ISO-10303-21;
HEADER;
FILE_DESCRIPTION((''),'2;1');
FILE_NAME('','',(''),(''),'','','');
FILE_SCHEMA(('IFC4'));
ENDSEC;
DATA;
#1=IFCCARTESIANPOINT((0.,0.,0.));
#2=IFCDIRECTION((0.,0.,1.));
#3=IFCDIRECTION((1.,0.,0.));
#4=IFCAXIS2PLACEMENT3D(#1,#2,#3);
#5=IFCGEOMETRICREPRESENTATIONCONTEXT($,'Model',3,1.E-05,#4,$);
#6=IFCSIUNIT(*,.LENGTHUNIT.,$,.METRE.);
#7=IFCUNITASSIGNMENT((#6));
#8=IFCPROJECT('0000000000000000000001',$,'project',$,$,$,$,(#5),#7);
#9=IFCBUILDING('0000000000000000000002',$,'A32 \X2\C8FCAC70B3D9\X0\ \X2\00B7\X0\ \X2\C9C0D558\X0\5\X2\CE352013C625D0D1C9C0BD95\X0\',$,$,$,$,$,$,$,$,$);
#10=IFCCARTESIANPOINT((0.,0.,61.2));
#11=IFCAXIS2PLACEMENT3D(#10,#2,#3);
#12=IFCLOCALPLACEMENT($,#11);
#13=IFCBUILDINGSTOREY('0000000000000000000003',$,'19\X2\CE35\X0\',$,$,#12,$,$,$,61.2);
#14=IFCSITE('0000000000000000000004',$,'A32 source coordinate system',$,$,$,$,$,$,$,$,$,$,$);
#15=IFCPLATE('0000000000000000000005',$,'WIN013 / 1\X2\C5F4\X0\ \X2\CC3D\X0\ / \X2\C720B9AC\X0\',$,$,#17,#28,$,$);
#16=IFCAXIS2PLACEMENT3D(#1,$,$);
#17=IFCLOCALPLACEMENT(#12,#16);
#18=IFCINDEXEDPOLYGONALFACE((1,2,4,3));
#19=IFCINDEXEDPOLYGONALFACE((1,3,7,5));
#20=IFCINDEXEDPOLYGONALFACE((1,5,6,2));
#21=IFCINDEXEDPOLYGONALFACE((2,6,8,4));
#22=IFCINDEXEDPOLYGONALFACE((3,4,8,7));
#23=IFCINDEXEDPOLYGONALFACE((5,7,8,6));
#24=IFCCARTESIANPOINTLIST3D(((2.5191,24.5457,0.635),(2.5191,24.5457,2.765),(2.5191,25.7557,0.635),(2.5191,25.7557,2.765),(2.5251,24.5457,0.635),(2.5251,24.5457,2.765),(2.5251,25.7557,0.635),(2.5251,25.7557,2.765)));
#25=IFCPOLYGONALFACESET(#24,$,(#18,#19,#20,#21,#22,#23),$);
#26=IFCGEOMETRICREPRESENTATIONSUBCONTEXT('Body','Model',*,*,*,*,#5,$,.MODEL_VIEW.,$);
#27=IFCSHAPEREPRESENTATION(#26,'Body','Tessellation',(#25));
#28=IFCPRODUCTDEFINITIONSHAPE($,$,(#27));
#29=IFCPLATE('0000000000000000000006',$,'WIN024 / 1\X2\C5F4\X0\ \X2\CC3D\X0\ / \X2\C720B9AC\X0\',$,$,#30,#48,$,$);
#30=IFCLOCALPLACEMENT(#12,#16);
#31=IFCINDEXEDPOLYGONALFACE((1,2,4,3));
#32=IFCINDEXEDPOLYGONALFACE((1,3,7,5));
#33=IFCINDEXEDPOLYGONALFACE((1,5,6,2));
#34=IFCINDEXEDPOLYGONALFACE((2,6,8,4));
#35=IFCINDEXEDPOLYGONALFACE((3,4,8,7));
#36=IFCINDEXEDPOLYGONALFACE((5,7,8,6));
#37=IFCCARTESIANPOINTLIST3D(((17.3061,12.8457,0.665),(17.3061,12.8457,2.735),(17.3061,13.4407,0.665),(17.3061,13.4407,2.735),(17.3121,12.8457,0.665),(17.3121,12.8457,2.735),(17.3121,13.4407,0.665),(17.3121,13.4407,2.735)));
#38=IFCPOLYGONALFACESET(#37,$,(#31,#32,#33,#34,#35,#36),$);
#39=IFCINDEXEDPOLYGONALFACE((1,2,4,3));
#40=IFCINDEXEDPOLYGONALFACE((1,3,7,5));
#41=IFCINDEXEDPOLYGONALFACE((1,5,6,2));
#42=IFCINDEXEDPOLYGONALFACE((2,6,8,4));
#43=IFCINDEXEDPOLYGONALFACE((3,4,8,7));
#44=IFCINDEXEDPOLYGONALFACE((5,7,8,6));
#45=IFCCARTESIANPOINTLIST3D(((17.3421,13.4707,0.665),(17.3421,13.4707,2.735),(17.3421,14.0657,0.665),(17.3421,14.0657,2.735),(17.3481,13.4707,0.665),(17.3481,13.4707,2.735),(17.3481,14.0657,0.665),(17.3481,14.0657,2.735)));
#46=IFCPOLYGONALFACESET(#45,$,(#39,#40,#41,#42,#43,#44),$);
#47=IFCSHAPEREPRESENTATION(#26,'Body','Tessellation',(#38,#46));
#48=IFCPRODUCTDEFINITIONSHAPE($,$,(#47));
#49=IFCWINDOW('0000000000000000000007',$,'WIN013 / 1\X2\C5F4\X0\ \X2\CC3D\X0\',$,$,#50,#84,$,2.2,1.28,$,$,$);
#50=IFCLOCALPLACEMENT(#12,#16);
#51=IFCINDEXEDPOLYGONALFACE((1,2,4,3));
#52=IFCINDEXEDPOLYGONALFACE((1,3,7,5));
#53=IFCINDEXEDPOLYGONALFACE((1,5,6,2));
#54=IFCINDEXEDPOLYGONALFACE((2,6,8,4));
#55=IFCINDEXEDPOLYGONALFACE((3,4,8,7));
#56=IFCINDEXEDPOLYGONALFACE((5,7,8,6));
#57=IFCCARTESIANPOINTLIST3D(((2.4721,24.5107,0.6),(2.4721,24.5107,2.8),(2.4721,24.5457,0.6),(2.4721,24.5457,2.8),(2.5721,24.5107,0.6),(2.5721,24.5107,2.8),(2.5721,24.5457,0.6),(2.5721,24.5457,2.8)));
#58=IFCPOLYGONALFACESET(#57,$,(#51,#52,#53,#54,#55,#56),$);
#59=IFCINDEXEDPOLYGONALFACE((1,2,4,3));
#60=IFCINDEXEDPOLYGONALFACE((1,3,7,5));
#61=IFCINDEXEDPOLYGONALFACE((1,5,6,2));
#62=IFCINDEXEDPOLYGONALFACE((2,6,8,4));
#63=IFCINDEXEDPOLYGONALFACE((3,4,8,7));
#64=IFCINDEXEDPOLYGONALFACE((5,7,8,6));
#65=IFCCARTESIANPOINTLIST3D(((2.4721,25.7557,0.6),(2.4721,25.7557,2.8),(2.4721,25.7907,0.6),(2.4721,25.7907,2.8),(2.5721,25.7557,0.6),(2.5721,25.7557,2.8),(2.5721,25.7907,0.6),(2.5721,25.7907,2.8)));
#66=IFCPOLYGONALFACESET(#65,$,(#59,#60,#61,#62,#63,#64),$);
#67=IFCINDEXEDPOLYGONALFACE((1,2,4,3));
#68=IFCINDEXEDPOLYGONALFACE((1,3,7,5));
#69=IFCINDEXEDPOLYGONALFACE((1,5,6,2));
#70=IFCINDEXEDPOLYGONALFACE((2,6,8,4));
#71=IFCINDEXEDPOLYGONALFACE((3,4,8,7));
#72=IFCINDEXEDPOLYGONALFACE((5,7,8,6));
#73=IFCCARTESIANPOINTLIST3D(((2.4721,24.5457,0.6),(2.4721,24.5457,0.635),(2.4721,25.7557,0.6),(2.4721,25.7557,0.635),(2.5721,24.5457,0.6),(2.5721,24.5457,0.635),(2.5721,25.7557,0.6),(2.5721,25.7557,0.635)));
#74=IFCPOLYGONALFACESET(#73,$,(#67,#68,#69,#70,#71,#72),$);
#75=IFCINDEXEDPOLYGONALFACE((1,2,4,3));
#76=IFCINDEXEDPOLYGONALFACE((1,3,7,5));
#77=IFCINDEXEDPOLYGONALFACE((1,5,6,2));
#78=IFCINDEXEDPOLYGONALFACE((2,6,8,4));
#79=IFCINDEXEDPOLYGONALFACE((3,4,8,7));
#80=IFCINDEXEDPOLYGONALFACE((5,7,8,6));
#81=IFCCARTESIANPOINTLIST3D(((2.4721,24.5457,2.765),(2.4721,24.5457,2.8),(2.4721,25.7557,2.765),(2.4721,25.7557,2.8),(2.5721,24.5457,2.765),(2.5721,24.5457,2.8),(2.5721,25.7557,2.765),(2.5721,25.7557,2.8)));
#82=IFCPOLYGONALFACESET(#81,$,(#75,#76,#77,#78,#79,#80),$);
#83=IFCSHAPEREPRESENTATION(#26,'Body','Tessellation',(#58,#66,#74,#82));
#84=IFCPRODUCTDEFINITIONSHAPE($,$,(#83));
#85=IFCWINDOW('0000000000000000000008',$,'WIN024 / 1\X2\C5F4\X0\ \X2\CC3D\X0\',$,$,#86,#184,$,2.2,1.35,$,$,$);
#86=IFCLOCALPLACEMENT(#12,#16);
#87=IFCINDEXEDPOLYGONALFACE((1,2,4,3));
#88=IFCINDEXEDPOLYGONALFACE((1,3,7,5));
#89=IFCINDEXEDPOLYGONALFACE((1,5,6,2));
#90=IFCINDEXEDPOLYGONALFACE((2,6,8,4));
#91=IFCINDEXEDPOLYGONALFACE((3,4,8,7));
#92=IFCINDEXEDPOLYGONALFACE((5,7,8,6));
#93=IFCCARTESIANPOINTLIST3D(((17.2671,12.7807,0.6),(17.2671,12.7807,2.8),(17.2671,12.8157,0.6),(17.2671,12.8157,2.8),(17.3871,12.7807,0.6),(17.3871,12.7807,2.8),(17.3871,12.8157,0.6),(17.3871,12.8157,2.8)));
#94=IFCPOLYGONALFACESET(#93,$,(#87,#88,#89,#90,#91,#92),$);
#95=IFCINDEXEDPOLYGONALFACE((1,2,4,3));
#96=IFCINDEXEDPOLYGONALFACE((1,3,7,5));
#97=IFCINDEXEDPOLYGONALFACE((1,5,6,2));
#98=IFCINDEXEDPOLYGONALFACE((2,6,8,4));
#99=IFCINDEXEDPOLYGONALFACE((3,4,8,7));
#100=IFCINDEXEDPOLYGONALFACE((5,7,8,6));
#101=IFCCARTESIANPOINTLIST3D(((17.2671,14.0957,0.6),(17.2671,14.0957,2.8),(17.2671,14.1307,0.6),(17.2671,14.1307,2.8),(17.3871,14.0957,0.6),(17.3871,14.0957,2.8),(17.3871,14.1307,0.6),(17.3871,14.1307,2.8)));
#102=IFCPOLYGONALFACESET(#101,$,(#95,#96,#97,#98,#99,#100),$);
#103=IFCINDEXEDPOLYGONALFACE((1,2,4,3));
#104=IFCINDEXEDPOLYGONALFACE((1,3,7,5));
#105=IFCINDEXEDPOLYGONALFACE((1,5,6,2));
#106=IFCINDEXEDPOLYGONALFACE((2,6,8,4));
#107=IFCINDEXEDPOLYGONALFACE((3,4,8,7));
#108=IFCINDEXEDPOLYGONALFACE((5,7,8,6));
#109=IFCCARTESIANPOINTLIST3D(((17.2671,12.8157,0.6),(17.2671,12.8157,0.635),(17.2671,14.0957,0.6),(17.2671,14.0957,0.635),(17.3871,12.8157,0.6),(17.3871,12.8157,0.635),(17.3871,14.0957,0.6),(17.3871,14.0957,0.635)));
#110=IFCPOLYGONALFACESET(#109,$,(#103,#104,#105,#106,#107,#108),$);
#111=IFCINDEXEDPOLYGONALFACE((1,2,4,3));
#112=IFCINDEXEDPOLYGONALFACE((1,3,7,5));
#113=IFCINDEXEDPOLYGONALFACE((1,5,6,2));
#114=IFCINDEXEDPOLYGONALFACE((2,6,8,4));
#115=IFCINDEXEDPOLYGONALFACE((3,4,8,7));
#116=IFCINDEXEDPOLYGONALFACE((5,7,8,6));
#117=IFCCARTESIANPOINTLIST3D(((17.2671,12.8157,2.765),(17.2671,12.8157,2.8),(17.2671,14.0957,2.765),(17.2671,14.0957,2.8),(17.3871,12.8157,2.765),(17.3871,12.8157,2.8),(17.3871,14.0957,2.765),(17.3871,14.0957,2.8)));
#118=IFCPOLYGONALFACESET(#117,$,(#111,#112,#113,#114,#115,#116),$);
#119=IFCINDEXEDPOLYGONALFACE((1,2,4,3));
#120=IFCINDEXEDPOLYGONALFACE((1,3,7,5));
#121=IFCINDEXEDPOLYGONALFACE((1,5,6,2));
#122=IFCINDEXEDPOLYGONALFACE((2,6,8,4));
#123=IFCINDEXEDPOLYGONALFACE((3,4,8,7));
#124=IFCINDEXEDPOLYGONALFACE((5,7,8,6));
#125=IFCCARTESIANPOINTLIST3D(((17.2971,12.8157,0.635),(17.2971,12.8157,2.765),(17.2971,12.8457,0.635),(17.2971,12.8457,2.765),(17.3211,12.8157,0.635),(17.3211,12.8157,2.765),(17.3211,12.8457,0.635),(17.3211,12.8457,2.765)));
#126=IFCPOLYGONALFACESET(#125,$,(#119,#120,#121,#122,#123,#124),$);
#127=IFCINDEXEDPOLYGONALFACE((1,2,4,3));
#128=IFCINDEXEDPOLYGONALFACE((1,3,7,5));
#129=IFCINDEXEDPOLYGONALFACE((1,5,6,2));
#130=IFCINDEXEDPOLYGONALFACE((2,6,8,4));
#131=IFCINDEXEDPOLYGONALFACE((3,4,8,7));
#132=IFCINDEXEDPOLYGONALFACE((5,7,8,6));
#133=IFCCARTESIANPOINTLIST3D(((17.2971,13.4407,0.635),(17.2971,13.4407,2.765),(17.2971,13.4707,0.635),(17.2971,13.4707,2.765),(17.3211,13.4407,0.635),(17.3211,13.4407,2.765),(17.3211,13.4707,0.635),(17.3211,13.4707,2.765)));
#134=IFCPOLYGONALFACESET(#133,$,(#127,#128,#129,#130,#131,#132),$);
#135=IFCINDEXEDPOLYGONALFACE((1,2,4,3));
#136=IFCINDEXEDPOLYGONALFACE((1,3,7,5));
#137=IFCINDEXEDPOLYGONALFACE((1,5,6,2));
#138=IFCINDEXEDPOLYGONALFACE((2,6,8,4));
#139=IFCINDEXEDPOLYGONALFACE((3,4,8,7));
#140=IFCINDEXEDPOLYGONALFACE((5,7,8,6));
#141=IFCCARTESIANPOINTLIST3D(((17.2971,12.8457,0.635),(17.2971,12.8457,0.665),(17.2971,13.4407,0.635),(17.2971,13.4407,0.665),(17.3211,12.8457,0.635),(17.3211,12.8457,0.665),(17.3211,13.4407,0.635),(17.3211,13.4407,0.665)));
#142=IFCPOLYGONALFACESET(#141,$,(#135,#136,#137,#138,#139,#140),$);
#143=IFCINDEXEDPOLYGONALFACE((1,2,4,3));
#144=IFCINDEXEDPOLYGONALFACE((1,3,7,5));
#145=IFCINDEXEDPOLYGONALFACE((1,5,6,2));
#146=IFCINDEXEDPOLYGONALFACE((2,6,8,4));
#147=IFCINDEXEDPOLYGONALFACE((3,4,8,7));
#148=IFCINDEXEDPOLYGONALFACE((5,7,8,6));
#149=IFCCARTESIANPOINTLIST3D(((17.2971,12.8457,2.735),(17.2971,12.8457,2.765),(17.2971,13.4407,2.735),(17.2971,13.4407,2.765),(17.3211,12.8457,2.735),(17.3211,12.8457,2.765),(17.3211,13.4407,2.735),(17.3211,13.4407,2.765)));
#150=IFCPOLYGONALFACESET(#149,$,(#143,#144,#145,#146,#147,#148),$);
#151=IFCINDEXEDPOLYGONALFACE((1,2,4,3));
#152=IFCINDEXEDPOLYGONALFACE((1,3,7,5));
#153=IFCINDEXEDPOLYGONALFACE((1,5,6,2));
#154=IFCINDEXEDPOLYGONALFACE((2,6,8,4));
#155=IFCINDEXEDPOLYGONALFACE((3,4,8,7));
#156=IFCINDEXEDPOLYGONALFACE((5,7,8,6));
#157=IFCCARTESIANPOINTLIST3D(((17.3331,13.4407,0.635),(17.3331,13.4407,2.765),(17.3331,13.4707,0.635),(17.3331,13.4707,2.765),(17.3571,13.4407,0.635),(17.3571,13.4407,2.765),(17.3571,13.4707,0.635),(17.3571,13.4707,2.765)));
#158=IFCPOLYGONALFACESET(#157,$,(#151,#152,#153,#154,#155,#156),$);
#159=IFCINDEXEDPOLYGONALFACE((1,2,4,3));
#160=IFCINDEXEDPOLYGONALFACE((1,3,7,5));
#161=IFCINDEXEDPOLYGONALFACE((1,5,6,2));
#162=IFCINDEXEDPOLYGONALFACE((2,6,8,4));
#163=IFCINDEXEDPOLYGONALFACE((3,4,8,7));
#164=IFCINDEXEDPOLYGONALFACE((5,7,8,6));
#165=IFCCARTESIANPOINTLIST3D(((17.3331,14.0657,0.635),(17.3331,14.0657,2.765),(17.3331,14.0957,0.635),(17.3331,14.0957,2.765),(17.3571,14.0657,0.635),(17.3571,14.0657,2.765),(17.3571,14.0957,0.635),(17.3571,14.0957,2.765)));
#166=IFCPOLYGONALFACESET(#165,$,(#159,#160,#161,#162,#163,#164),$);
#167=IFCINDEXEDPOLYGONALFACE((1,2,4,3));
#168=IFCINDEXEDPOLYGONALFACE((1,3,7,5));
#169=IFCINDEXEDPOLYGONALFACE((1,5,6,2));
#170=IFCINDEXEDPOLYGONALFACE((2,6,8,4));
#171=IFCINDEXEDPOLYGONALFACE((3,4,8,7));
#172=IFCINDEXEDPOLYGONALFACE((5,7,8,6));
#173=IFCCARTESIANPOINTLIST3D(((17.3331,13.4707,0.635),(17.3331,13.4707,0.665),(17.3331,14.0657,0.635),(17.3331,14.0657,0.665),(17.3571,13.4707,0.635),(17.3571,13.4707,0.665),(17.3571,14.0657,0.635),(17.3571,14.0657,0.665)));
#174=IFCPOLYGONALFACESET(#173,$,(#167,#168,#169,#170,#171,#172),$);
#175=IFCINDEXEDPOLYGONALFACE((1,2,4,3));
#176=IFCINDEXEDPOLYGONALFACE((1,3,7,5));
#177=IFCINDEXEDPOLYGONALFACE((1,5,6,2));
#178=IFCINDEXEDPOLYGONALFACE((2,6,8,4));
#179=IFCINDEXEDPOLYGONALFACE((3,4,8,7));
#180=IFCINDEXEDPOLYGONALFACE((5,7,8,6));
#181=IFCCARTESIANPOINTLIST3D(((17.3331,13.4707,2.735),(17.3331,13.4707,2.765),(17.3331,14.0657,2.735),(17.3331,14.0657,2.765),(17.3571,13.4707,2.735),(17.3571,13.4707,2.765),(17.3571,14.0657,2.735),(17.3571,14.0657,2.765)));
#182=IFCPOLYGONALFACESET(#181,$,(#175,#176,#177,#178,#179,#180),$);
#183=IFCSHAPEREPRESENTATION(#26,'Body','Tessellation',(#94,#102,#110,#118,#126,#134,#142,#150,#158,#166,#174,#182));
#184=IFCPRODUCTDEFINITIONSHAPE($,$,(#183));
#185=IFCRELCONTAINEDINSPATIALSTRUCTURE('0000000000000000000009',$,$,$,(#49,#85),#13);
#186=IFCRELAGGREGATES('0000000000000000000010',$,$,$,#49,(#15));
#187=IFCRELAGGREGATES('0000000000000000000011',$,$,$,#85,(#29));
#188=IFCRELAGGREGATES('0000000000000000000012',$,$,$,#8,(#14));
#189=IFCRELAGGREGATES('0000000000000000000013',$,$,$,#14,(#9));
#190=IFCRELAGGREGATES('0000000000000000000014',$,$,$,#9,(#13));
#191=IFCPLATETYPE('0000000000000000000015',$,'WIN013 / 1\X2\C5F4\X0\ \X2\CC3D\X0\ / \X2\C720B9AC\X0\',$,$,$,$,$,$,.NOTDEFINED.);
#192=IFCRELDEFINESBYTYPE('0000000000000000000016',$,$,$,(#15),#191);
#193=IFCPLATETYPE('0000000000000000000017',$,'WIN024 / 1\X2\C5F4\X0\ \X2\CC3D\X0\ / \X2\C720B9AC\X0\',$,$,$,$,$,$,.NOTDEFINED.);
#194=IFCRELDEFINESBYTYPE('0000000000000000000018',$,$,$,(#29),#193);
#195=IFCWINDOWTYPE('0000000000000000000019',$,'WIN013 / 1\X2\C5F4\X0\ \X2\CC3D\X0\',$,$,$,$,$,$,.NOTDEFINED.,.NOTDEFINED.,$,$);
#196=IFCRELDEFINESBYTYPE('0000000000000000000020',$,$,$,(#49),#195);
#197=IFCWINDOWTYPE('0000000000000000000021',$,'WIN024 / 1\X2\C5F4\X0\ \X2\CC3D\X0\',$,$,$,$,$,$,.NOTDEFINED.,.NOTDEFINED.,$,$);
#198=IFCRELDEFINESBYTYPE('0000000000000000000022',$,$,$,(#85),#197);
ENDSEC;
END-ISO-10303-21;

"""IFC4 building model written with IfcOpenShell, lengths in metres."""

from ifc_helpers import new_model, si_unit, frame, origin, origin_with_axes, place, context, subcontext, project, spatial, polyline, outline, extrude, source, transform, mapped, type_object, type_shapes, element, aggregate, save


model = new_model("IFC4")

# Units and contexts
model_context = context("Model", 3, precision=1e-05, world=origin_with_axes())
body_context = subcontext(model_context, "Body", "Model", "MODEL_VIEW")
ifc_project = project(units=[si_unit("LENGTHUNIT", "METRE")], contexts=[model_context])

# Plates
plate_type_1 = type_object("IfcPlateType", Name="WIN013 / 1열 창 / 유리", PredefinedType="NOTDEFINED")
shared_shape_1 = source(origin(), body_context, "Body", "SweptSolid", [
    extrude(outline(polyline([(2.5191, 24.5457), (2.5191, 25.7557), (2.5251, 25.7557), (2.5251, 24.5457), (2.5191, 24.5457)])), frame((0.0, 0.0, 0.635)), (0.0, 0.0, 1.0), 2.13),
])
type_shapes(plate_type_1, [shared_shape_1])
storey_placement = place(None, frame((0.0, 0.0, 61.2), z_axis=(0.0, 0.0, 1.0), x_axis=(1.0, 0.0, 0.0)))
window_1_placement = place(storey_placement, origin_with_axes())
plate_1_placement = place(window_1_placement, origin_with_axes())
plate_1 = element("IfcPlate", 1, at=plate_1_placement, type_object=plate_type_1, Name="WIN013 / 1열 창 / 유리", context=body_context, shape_type="MappedRepresentation", body=[
    mapped(shared_shape_1, transform((0.0, 0.0, 0.0), scale=1.0)),
])
plate_type_2 = type_object("IfcPlateType", Name="WIN024 / 1열 창 / 유리", PredefinedType="NOTDEFINED")
shared_shape_2 = source(origin(), body_context, "Body", "SweptSolid", [
    extrude(outline(polyline([(17.3061, 12.8457), (17.3061, 13.4407), (17.3121, 13.4407), (17.3121, 12.8457), (17.3061, 12.8457)])), frame((0.0, 0.0, 0.665)), (0.0, 0.0, 1.0), 2.07),
    extrude(outline(polyline([(17.3421, 13.4707), (17.3421, 14.0657), (17.3481, 14.0657), (17.3481, 13.4707), (17.3421, 13.4707)])), frame((0.0, 0.0, 0.665)), (0.0, 0.0, 1.0), 2.07),
])
type_shapes(plate_type_2, [shared_shape_2])
window_2_placement = place(storey_placement, origin_with_axes())
plate_2_placement = place(window_2_placement, origin_with_axes())
plate_2 = element("IfcPlate", 2, at=plate_2_placement, type_object=plate_type_2, Name="WIN024 / 1열 창 / 유리", context=body_context, shape_type="MappedRepresentation", body=[
    mapped(shared_shape_2, transform((0.0, 0.0, 0.0), scale=1.0)),
])

# Site, building, storey
site = spatial("IfcSite", under=ifc_project, Name="A32 source coordinate system")
building = spatial("IfcBuilding", under=site, Name="A32 주거동 · 지하5층–옥탑지붕")
storey = spatial("IfcBuildingStorey", under=building, at=storey_placement, Name="19층", Elevation=61.2)

# Windows
window_type_1 = type_object("IfcWindowType", Name="WIN013 / 1열 창", PartitioningType="NOTDEFINED", PredefinedType="NOTDEFINED")
shared_shape_3 = source(origin(), body_context, "Body", "SweptSolid", [
    extrude(outline(polyline([(2.4721, 24.5107), (2.4721, 24.5457), (2.5721, 24.5457), (2.5721, 24.5107), (2.4721, 24.5107)])), frame((0.0, 0.0, 0.6)), (0.0, 0.0, 1.0), 2.2),
    extrude(outline(polyline([(2.4721, 25.7557), (2.4721, 25.7907), (2.5721, 25.7907), (2.5721, 25.7557), (2.4721, 25.7557)])), frame((0.0, 0.0, 0.6)), (0.0, 0.0, 1.0), 2.2),
    extrude(outline(polyline([(2.4721, 24.5457), (2.4721, 25.7557), (2.5721, 25.7557), (2.5721, 24.5457), (2.4721, 24.5457)])), frame((0.0, 0.0, 0.6)), (0.0, 0.0, 1.0), 0.035),
    extrude(outline(polyline([(2.4721, 24.5457), (2.4721, 25.7557), (2.5721, 25.7557), (2.5721, 24.5457), (2.4721, 24.5457)])), frame((0.0, 0.0, 2.765)), (0.0, 0.0, 1.0), 0.035),
])
type_shapes(window_type_1, [shared_shape_3])
window_1 = element("IfcWindow", 3, at=window_1_placement, inside=storey, type_object=window_type_1, Name="WIN013 / 1열 창", OverallHeight=2.2, OverallWidth=1.28, context=body_context, shape_type="MappedRepresentation", body=[
    mapped(shared_shape_3, transform((0.0, 0.0, 0.0), scale=1.0)),
])
aggregate(window_1, [plate_1])
window_type_2 = type_object("IfcWindowType", Name="WIN024 / 1열 창", PartitioningType="NOTDEFINED", PredefinedType="NOTDEFINED")
shared_shape_4 = source(origin(), body_context, "Body", "SweptSolid", [
    extrude(outline(polyline([(17.2671, 12.7807), (17.2671, 12.8157), (17.3871, 12.8157), (17.3871, 12.7807), (17.2671, 12.7807)])), frame((0.0, 0.0, 0.6)), (0.0, 0.0, 1.0), 2.2),
    extrude(outline(polyline([(17.2671, 14.0957), (17.2671, 14.1307), (17.3871, 14.1307), (17.3871, 14.0957), (17.2671, 14.0957)])), frame((0.0, 0.0, 0.6)), (0.0, 0.0, 1.0), 2.2),
    extrude(outline(polyline([(17.2671, 12.8157), (17.2671, 14.0957), (17.3871, 14.0957), (17.3871, 12.8157), (17.2671, 12.8157)])), frame((0.0, 0.0, 0.6)), (0.0, 0.0, 1.0), 0.035),
    extrude(outline(polyline([(17.2671, 12.8157), (17.2671, 14.0957), (17.3871, 14.0957), (17.3871, 12.8157), (17.2671, 12.8157)])), frame((0.0, 0.0, 2.765)), (0.0, 0.0, 1.0), 0.035),
    extrude(outline(polyline([(17.2971, 12.8157), (17.2971, 12.8457), (17.3211, 12.8457), (17.3211, 12.8157), (17.2971, 12.8157)])), frame((0.0, 0.0, 0.635)), (0.0, 0.0, 1.0), 2.13),
    extrude(outline(polyline([(17.2971, 13.4407), (17.2971, 13.4707), (17.3211, 13.4707), (17.3211, 13.4407), (17.2971, 13.4407)])), frame((0.0, 0.0, 0.635)), (0.0, 0.0, 1.0), 2.13),
    extrude(outline(polyline([(17.2971, 12.8457), (17.2971, 13.4407), (17.3211, 13.4407), (17.3211, 12.8457), (17.2971, 12.8457)])), frame((0.0, 0.0, 0.635)), (0.0, 0.0, 1.0), 0.03),
    extrude(outline(polyline([(17.2971, 12.8457), (17.2971, 13.4407), (17.3211, 13.4407), (17.3211, 12.8457), (17.2971, 12.8457)])), frame((0.0, 0.0, 2.735)), (0.0, 0.0, 1.0), 0.03),
    extrude(outline(polyline([(17.3331, 13.4407), (17.3331, 13.4707), (17.3571, 13.4707), (17.3571, 13.4407), (17.3331, 13.4407)])), frame((0.0, 0.0, 0.635)), (0.0, 0.0, 1.0), 2.13),
    extrude(outline(polyline([(17.3331, 14.0657), (17.3331, 14.0957), (17.3571, 14.0957), (17.3571, 14.0657), (17.3331, 14.0657)])), frame((0.0, 0.0, 0.635)), (0.0, 0.0, 1.0), 2.13),
    extrude(outline(polyline([(17.3331, 13.4707), (17.3331, 14.0657), (17.3571, 14.0657), (17.3571, 13.4707), (17.3331, 13.4707)])), frame((0.0, 0.0, 0.635)), (0.0, 0.0, 1.0), 0.03),
    extrude(outline(polyline([(17.3331, 13.4707), (17.3331, 14.0657), (17.3571, 14.0657), (17.3571, 13.4707), (17.3331, 13.4707)])), frame((0.0, 0.0, 2.735)), (0.0, 0.0, 1.0), 0.03),
])
type_shapes(window_type_2, [shared_shape_4])
window_2 = element("IfcWindow", 4, at=window_2_placement, inside=storey, type_object=window_type_2, Name="WIN024 / 1열 창", OverallHeight=2.2, OverallWidth=1.35, context=body_context, shape_type="MappedRepresentation", body=[
    mapped(shared_shape_4, transform((0.0, 0.0, 0.0), scale=1.0)),
])
aggregate(window_2, [plate_2])

save(model, "model.ifc")
